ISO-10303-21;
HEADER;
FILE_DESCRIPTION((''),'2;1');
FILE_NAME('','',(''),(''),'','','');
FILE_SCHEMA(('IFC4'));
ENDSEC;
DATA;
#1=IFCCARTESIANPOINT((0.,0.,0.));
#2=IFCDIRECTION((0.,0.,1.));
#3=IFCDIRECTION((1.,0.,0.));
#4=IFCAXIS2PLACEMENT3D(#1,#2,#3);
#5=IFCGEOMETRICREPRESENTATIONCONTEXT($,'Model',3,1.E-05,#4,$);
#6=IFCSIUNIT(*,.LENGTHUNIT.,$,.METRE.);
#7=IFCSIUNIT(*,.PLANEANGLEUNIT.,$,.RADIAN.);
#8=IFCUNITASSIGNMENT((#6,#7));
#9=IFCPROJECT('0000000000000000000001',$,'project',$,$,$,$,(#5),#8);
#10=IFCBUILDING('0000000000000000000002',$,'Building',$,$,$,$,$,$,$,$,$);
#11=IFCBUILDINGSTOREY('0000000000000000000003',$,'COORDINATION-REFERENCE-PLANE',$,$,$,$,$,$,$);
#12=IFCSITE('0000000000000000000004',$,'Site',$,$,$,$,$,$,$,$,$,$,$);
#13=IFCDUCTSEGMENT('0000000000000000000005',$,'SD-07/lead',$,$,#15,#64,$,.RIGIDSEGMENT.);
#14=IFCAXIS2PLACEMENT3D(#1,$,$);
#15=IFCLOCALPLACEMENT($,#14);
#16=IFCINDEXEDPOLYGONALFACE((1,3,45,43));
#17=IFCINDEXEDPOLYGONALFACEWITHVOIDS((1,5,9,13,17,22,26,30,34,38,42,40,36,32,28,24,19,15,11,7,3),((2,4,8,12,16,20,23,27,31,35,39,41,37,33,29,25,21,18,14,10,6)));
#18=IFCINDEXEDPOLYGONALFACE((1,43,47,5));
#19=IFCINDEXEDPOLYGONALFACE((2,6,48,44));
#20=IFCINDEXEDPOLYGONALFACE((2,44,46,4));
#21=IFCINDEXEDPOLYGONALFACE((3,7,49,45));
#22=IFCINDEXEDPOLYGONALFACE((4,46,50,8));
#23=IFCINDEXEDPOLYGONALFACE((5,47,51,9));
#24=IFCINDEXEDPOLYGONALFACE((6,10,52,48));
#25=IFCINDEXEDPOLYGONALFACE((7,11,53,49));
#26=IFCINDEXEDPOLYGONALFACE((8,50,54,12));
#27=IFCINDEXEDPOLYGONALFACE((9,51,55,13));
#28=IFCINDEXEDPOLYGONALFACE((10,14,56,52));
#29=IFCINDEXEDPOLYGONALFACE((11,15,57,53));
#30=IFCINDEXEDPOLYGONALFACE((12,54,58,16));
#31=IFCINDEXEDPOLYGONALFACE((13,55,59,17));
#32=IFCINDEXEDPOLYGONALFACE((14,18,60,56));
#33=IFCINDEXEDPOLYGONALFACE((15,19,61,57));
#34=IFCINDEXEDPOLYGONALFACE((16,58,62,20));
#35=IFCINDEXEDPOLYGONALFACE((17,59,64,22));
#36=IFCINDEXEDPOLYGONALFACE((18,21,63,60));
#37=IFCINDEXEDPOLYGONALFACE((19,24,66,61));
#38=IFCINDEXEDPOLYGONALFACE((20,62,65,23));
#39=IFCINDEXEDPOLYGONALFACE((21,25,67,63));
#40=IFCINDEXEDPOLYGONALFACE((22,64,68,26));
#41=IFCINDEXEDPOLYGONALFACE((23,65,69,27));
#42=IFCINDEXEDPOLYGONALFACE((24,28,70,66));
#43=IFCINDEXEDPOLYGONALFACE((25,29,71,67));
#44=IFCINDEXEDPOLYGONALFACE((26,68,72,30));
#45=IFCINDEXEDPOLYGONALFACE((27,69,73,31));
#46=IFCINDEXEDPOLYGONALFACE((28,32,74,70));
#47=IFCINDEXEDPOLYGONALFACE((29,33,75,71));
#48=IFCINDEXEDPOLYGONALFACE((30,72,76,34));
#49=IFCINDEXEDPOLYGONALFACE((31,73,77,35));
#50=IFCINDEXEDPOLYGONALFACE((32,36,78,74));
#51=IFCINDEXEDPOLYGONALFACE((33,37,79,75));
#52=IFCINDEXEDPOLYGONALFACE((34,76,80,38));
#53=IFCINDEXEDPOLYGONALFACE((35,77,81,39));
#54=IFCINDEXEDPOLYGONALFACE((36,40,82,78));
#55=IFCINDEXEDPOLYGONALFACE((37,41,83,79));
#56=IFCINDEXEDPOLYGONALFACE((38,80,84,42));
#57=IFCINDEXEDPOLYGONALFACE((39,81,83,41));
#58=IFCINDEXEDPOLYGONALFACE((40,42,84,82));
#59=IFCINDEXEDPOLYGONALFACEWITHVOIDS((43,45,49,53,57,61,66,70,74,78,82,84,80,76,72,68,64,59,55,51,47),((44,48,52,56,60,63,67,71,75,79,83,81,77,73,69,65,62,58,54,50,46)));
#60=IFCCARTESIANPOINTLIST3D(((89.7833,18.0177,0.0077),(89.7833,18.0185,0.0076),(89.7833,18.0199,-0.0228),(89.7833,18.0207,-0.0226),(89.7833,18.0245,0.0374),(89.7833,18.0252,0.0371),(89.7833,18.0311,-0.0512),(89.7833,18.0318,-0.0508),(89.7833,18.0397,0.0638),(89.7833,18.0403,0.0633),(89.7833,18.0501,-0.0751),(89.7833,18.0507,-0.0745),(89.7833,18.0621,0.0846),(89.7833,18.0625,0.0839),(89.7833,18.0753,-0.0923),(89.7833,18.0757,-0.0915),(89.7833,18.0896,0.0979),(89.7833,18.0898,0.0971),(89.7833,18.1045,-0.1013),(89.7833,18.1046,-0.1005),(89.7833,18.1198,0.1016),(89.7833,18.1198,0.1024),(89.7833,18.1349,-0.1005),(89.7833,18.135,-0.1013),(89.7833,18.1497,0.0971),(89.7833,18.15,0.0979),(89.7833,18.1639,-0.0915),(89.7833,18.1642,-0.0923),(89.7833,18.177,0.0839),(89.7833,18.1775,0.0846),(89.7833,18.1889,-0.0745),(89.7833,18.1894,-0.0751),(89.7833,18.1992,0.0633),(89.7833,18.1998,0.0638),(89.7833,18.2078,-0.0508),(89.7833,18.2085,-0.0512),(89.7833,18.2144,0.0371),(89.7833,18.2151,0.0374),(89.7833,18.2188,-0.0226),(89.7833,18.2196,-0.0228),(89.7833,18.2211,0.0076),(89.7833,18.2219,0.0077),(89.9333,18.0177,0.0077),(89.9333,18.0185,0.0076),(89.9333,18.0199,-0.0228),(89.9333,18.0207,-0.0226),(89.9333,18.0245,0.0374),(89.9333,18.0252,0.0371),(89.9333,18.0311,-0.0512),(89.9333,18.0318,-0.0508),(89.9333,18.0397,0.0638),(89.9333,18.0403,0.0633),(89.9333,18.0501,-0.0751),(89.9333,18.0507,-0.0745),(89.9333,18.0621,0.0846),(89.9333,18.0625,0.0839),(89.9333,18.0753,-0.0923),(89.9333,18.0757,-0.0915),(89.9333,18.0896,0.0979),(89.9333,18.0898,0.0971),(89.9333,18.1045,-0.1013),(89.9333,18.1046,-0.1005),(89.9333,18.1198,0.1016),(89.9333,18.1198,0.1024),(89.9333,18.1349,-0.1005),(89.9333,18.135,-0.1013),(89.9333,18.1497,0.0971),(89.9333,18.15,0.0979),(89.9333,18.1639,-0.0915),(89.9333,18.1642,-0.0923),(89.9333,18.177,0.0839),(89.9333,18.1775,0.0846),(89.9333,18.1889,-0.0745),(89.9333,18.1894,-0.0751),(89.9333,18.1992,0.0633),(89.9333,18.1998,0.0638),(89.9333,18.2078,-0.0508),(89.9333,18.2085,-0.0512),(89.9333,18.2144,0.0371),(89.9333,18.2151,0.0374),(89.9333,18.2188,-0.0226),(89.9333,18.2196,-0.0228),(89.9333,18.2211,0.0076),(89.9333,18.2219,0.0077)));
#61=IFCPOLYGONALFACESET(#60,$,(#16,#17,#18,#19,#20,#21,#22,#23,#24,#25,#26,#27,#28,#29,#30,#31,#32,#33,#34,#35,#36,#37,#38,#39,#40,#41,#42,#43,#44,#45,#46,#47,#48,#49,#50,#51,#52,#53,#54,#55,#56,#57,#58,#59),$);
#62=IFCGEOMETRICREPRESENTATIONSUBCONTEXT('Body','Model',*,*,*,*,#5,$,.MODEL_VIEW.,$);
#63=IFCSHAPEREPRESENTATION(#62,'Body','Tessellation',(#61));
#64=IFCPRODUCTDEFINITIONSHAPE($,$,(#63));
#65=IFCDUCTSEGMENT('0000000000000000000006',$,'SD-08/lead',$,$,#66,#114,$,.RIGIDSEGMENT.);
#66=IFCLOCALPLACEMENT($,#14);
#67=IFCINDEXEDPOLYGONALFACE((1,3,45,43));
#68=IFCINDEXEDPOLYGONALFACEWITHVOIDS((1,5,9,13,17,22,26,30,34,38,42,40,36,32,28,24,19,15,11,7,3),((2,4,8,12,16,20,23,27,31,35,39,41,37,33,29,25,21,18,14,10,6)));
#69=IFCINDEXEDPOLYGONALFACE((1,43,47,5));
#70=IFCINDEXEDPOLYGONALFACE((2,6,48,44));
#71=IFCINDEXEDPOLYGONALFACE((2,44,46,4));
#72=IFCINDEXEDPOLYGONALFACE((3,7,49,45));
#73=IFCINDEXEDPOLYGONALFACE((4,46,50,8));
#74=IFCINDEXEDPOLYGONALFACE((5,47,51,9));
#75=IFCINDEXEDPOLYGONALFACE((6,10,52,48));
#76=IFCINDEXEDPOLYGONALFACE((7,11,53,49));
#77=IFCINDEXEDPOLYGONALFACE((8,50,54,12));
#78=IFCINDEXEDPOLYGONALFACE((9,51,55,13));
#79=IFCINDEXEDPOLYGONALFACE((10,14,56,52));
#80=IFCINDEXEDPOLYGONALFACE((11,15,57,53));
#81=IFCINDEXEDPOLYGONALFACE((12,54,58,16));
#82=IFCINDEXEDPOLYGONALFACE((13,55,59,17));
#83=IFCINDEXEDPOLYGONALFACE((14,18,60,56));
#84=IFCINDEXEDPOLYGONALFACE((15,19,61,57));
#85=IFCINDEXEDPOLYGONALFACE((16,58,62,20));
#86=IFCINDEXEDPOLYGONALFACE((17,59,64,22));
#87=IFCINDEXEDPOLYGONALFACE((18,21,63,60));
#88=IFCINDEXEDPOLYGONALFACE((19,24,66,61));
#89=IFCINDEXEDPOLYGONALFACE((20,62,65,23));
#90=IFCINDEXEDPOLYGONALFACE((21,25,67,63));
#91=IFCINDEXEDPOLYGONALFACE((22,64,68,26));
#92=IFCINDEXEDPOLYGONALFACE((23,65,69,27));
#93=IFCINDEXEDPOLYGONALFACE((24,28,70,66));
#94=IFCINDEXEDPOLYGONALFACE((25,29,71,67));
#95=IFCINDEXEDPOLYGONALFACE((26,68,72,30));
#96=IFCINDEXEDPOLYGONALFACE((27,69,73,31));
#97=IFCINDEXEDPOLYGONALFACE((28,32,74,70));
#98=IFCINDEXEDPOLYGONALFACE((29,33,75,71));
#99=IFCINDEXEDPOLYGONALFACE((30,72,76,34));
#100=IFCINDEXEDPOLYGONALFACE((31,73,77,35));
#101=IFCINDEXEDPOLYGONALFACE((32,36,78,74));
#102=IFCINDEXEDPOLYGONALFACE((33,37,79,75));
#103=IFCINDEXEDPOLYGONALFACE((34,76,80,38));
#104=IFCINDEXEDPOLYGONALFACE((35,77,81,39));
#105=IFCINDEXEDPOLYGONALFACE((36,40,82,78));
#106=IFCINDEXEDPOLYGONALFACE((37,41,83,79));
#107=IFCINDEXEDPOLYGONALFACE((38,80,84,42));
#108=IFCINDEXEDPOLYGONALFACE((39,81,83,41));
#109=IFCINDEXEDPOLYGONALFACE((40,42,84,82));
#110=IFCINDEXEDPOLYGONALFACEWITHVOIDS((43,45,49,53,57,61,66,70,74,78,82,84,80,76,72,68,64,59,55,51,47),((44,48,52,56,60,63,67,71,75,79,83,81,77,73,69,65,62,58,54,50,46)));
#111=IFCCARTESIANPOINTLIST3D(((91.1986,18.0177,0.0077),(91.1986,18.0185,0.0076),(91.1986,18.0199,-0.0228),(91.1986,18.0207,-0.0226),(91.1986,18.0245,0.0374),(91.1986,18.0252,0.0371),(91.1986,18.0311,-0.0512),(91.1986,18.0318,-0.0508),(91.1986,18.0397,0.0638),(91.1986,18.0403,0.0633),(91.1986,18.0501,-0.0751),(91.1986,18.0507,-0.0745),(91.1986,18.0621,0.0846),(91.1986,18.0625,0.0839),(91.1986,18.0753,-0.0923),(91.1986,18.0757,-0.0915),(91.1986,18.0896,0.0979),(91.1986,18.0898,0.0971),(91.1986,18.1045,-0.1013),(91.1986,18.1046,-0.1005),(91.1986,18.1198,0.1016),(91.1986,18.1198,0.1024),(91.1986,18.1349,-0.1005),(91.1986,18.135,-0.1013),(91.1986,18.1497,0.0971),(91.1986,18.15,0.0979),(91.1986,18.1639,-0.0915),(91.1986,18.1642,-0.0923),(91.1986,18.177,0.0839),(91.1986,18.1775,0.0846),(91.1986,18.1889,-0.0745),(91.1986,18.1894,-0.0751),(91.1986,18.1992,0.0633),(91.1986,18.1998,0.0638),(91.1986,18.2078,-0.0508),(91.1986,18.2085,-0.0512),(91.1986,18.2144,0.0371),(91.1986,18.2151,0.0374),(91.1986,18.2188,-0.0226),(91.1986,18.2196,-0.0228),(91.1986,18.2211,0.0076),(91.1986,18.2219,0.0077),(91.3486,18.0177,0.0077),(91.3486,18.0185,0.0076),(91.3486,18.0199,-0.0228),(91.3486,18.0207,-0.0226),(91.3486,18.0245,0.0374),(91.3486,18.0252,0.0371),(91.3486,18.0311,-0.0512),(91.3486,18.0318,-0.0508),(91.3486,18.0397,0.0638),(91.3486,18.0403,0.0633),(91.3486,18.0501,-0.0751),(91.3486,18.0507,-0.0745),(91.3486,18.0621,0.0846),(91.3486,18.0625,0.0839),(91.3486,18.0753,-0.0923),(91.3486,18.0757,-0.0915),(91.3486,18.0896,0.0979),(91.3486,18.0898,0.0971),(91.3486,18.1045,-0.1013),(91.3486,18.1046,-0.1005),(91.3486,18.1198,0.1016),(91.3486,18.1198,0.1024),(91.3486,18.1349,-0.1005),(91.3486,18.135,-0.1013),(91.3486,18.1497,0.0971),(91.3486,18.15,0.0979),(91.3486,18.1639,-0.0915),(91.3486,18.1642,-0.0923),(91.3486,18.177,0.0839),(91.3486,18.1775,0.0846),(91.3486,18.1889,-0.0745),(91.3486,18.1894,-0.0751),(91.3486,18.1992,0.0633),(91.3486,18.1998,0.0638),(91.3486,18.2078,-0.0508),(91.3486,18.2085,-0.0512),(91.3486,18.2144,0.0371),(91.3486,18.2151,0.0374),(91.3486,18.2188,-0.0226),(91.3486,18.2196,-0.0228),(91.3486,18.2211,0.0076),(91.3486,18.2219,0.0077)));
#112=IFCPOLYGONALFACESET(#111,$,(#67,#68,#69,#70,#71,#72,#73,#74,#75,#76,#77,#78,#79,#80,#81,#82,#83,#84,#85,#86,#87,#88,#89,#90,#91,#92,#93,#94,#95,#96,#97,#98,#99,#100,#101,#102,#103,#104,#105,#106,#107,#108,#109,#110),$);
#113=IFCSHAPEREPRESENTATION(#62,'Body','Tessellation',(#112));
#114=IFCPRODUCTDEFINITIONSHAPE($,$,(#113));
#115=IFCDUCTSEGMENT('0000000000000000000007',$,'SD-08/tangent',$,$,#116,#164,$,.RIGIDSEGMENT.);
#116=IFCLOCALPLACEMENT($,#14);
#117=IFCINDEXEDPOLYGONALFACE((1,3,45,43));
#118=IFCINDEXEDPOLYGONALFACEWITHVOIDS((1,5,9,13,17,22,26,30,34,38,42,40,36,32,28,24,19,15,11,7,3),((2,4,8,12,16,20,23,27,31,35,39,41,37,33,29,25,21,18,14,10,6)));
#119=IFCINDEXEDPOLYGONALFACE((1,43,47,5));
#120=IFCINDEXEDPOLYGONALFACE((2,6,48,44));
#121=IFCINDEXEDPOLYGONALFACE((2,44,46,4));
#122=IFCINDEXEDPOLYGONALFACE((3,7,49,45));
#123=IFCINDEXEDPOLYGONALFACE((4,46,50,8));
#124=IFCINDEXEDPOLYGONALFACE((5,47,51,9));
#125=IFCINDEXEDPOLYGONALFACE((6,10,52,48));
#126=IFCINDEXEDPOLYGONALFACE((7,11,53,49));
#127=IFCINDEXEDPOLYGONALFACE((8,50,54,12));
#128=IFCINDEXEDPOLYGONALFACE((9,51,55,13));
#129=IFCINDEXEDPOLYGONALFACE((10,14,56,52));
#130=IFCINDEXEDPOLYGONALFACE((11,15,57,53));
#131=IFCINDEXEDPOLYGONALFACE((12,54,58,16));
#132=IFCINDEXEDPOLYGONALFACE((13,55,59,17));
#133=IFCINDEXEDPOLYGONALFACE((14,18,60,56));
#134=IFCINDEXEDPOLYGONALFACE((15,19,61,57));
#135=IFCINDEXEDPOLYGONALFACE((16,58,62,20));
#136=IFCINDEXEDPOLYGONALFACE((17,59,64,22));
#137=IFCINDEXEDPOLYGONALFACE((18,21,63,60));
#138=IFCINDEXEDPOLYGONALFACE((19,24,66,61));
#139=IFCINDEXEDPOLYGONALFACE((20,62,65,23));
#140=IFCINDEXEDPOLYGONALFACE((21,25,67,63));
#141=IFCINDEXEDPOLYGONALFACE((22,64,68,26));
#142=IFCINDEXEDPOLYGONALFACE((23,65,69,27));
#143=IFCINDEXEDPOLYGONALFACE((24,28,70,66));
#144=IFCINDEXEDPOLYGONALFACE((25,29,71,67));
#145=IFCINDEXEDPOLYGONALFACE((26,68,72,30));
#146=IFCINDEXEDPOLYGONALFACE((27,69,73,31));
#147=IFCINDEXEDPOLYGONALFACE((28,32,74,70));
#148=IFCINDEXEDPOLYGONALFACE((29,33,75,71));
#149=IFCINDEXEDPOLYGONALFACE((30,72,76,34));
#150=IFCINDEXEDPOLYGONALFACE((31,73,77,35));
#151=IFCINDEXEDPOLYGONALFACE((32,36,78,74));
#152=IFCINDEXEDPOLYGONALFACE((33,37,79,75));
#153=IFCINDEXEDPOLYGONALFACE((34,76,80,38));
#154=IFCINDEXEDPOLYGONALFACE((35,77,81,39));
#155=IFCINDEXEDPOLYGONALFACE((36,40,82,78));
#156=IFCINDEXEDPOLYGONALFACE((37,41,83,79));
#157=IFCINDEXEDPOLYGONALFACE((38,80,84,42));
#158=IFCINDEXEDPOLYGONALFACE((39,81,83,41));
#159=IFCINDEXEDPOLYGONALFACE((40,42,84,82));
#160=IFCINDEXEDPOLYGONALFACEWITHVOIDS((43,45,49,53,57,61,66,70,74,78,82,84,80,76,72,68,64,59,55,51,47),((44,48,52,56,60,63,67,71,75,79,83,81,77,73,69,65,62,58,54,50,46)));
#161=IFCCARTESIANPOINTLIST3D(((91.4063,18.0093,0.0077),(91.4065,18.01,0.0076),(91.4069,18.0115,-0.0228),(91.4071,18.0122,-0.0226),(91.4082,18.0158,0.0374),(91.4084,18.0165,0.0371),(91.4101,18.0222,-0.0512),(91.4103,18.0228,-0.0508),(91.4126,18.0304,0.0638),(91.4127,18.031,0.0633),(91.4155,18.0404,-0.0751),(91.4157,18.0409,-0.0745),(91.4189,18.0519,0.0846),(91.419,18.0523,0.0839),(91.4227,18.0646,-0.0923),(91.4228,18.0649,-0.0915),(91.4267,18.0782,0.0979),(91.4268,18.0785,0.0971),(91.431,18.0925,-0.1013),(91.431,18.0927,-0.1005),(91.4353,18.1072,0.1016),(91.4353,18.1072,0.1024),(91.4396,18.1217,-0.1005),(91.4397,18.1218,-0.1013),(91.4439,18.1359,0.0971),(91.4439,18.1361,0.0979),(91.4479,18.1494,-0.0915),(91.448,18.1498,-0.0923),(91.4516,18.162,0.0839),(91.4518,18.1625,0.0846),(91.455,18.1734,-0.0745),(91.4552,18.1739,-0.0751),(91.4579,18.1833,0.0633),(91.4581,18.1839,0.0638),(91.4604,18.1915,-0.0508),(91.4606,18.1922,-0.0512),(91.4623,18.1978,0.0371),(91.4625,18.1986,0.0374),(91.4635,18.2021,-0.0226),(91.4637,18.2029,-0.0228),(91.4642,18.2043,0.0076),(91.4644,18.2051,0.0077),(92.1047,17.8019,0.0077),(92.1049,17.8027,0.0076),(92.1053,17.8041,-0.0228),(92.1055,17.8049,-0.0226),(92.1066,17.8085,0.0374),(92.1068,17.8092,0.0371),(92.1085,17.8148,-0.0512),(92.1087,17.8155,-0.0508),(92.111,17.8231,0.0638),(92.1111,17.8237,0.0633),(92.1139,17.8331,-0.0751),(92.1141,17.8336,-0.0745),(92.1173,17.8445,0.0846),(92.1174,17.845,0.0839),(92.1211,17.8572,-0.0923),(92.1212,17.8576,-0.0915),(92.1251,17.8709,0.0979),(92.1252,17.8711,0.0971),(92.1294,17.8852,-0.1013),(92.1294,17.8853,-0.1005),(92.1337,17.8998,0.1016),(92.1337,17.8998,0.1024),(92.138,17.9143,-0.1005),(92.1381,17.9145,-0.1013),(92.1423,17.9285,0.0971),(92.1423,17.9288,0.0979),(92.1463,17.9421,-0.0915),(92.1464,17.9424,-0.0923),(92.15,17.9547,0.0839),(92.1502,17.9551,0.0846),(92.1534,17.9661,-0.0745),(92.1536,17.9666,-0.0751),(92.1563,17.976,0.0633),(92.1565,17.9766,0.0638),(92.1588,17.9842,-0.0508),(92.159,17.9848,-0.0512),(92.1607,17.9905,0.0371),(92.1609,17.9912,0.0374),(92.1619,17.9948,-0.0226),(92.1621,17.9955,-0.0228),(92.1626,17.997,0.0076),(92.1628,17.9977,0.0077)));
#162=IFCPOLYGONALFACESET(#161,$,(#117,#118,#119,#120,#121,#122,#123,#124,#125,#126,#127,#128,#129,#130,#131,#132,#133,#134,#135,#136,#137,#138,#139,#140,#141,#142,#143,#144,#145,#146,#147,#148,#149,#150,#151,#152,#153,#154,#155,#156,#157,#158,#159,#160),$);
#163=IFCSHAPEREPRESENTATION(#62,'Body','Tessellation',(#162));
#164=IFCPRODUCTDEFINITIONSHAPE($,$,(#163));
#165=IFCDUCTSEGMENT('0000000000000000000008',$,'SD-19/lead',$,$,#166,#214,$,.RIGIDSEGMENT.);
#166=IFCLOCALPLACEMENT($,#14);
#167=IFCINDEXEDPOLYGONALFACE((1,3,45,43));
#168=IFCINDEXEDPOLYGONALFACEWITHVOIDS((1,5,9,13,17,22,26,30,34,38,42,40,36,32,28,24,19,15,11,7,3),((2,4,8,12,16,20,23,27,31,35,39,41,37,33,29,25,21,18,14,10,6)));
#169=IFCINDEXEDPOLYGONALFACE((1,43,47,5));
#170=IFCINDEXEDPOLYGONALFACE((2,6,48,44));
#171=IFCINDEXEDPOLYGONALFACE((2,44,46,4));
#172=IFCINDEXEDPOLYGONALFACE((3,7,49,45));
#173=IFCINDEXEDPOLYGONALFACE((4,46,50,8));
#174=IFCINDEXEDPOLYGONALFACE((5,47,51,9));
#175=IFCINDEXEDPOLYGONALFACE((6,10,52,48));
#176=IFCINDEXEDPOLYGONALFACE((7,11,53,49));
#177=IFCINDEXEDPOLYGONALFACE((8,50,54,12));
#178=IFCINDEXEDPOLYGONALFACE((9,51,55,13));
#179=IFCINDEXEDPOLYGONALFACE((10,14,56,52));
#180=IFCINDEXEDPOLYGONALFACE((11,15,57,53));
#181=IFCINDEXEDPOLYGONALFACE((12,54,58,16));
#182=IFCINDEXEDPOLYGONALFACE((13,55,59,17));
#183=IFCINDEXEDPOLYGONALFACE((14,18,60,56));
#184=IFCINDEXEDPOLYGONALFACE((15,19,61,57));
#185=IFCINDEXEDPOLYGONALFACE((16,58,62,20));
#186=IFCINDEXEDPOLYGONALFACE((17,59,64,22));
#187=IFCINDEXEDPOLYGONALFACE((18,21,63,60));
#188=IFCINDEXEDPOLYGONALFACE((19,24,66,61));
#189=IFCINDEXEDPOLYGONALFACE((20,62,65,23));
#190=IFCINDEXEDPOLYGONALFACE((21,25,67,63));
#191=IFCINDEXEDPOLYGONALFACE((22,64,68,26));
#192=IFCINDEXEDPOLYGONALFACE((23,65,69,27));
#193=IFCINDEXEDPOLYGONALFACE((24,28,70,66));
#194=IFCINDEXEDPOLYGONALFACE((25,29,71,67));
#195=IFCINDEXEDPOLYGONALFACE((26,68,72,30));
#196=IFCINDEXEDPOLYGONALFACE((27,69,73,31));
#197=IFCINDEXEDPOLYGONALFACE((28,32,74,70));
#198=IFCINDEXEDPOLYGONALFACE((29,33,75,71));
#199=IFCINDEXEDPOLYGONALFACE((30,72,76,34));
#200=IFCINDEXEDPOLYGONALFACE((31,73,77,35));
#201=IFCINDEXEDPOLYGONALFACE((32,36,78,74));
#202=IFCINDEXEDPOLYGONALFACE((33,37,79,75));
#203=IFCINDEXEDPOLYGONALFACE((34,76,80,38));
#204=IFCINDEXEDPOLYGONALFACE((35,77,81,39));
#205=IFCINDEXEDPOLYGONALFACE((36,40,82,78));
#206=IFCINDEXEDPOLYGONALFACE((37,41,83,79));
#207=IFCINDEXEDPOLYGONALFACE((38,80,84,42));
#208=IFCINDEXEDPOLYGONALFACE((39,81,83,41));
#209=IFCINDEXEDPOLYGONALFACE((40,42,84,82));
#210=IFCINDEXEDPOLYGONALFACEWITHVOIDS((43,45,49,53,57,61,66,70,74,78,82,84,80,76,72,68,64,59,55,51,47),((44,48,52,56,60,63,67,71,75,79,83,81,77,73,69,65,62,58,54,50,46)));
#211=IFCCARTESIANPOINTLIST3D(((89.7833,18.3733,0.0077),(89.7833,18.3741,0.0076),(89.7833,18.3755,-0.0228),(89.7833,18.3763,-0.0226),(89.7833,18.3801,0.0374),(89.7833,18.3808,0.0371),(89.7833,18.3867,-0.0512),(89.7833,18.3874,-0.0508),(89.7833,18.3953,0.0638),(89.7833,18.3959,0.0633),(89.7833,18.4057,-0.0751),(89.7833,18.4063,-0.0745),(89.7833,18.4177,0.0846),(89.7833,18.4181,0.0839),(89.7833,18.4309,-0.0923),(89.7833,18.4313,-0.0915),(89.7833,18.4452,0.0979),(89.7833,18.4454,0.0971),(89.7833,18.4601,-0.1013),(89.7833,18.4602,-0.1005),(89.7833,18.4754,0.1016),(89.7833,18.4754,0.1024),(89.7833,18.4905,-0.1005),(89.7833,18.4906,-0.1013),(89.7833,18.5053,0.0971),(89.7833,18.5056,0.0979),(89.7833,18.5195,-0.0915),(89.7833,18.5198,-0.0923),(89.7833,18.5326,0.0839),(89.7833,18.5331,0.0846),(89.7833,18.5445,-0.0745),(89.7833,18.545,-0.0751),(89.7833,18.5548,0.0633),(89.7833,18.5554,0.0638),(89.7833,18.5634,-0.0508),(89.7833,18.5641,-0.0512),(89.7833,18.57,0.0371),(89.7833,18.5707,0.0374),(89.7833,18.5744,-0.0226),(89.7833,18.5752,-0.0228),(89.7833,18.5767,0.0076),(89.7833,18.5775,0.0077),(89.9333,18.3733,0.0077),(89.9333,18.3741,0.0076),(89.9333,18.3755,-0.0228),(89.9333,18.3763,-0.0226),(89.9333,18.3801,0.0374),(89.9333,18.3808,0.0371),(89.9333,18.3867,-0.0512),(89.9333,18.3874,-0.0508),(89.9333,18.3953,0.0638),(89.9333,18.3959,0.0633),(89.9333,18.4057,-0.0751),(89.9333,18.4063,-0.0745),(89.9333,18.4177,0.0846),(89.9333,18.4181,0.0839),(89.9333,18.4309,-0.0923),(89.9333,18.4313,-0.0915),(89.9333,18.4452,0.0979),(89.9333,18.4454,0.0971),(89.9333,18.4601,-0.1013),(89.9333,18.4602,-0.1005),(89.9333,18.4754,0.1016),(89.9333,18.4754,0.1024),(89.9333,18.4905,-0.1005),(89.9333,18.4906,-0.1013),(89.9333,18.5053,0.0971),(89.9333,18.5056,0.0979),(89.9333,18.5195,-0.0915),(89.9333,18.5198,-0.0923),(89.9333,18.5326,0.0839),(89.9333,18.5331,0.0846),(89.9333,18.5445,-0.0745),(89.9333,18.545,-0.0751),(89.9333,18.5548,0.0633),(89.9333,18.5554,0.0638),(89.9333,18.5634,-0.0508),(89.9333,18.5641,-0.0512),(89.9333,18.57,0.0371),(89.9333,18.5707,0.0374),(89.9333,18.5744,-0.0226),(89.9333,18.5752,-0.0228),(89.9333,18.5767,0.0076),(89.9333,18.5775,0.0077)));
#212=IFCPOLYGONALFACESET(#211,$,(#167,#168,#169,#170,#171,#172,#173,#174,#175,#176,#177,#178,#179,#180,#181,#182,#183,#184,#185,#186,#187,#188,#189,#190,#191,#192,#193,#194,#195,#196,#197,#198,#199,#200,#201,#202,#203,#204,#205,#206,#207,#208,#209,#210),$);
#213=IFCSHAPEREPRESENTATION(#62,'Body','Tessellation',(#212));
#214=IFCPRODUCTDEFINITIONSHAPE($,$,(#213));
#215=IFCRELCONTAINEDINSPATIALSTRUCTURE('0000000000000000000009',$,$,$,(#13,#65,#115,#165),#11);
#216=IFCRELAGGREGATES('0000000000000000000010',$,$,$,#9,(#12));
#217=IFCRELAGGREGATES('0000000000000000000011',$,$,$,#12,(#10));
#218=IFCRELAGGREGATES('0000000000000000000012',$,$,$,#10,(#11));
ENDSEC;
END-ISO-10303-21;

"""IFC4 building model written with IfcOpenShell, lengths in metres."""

from ifc_helpers import new_model, si_unit, frame, origin_with_axes, place, context, subcontext, project, spatial, hollow_circle, extrude, element, save


model = new_model("IFC4")

# Units and contexts
model_context_1 = context("Model", 3, precision=1e-05, world=origin_with_axes())
body_context_1 = subcontext(model_context_1, "Body", "Model", "MODEL_VIEW")
ifc_project = project(units=[si_unit("LENGTHUNIT", "METRE"), si_unit("PLANEANGLEUNIT", "RADIAN")], contexts=[model_context_1])

# Site, building, storey
site = spatial("IfcSite", under=ifc_project, Name="Site")
building = spatial("IfcBuilding", under=site, Name="Building")
storey = spatial("IfcBuildingStorey", under=building, Name="COORDINATION-REFERENCE-PLANE")

# Duct segments
for number, where, z_axis, x_axis, name in (
    (1, (89.9333, 18.1198, 0.0), (-1.0, 0.0, 0.0), (0.0, 0.0, 1.0), "SD-07/lead"),
    (2, (91.1986, 18.1198, 0.0), (1.0, 0.0, 0.0), (0.0, 0.0, 1.0), "SD-08/lead"),
):
    element("IfcDuctSegment", number, at=place(None, frame(where, z_axis=z_axis, x_axis=x_axis)), inside=storey, Name=name, PredefinedType="RIGIDSEGMENT", context=body_context_1, shape_type="SweptSolid", body=[
        extrude(hollow_circle(Radius=0.1024, WallThickness=0.0008), origin_with_axes(), (0.0, 0.0, 1.0), 0.15),
    ])

# Duct segment
duct_segment_1_placement = place(None, frame((91.4353, 18.1072, 0.0), z_axis=(0.958645, -0.284603, 0.0), x_axis=(0.0, 0.0, 1.0)))
element("IfcDuctSegment", 3, at=duct_segment_1_placement, inside=storey, Name="SD-08/tangent", PredefinedType="RIGIDSEGMENT", context=body_context_1, shape_type="SweptSolid", body=[
    extrude(hollow_circle(Radius=0.1024, WallThickness=0.0008), origin_with_axes(), (0.0, 0.0, 1.0), 0.7285),
])

# Duct segment
for number, where, z_axis, x_axis, name in (
    (4, (89.9333, 18.4754, 0.0), (-1.0, 0.0, 0.0), (0.0, 0.0, 1.0), "SD-19/lead"),
):
    element("IfcDuctSegment", number, at=place(None, frame(where, z_axis=z_axis, x_axis=x_axis)), inside=storey, Name=name, PredefinedType="RIGIDSEGMENT", context=body_context_1, shape_type="SweptSolid", body=[
        extrude(hollow_circle(Radius=0.1024, WallThickness=0.0008), origin_with_axes(), (0.0, 0.0, 1.0), 0.15),
    ])

save(model, "model.ifc")
